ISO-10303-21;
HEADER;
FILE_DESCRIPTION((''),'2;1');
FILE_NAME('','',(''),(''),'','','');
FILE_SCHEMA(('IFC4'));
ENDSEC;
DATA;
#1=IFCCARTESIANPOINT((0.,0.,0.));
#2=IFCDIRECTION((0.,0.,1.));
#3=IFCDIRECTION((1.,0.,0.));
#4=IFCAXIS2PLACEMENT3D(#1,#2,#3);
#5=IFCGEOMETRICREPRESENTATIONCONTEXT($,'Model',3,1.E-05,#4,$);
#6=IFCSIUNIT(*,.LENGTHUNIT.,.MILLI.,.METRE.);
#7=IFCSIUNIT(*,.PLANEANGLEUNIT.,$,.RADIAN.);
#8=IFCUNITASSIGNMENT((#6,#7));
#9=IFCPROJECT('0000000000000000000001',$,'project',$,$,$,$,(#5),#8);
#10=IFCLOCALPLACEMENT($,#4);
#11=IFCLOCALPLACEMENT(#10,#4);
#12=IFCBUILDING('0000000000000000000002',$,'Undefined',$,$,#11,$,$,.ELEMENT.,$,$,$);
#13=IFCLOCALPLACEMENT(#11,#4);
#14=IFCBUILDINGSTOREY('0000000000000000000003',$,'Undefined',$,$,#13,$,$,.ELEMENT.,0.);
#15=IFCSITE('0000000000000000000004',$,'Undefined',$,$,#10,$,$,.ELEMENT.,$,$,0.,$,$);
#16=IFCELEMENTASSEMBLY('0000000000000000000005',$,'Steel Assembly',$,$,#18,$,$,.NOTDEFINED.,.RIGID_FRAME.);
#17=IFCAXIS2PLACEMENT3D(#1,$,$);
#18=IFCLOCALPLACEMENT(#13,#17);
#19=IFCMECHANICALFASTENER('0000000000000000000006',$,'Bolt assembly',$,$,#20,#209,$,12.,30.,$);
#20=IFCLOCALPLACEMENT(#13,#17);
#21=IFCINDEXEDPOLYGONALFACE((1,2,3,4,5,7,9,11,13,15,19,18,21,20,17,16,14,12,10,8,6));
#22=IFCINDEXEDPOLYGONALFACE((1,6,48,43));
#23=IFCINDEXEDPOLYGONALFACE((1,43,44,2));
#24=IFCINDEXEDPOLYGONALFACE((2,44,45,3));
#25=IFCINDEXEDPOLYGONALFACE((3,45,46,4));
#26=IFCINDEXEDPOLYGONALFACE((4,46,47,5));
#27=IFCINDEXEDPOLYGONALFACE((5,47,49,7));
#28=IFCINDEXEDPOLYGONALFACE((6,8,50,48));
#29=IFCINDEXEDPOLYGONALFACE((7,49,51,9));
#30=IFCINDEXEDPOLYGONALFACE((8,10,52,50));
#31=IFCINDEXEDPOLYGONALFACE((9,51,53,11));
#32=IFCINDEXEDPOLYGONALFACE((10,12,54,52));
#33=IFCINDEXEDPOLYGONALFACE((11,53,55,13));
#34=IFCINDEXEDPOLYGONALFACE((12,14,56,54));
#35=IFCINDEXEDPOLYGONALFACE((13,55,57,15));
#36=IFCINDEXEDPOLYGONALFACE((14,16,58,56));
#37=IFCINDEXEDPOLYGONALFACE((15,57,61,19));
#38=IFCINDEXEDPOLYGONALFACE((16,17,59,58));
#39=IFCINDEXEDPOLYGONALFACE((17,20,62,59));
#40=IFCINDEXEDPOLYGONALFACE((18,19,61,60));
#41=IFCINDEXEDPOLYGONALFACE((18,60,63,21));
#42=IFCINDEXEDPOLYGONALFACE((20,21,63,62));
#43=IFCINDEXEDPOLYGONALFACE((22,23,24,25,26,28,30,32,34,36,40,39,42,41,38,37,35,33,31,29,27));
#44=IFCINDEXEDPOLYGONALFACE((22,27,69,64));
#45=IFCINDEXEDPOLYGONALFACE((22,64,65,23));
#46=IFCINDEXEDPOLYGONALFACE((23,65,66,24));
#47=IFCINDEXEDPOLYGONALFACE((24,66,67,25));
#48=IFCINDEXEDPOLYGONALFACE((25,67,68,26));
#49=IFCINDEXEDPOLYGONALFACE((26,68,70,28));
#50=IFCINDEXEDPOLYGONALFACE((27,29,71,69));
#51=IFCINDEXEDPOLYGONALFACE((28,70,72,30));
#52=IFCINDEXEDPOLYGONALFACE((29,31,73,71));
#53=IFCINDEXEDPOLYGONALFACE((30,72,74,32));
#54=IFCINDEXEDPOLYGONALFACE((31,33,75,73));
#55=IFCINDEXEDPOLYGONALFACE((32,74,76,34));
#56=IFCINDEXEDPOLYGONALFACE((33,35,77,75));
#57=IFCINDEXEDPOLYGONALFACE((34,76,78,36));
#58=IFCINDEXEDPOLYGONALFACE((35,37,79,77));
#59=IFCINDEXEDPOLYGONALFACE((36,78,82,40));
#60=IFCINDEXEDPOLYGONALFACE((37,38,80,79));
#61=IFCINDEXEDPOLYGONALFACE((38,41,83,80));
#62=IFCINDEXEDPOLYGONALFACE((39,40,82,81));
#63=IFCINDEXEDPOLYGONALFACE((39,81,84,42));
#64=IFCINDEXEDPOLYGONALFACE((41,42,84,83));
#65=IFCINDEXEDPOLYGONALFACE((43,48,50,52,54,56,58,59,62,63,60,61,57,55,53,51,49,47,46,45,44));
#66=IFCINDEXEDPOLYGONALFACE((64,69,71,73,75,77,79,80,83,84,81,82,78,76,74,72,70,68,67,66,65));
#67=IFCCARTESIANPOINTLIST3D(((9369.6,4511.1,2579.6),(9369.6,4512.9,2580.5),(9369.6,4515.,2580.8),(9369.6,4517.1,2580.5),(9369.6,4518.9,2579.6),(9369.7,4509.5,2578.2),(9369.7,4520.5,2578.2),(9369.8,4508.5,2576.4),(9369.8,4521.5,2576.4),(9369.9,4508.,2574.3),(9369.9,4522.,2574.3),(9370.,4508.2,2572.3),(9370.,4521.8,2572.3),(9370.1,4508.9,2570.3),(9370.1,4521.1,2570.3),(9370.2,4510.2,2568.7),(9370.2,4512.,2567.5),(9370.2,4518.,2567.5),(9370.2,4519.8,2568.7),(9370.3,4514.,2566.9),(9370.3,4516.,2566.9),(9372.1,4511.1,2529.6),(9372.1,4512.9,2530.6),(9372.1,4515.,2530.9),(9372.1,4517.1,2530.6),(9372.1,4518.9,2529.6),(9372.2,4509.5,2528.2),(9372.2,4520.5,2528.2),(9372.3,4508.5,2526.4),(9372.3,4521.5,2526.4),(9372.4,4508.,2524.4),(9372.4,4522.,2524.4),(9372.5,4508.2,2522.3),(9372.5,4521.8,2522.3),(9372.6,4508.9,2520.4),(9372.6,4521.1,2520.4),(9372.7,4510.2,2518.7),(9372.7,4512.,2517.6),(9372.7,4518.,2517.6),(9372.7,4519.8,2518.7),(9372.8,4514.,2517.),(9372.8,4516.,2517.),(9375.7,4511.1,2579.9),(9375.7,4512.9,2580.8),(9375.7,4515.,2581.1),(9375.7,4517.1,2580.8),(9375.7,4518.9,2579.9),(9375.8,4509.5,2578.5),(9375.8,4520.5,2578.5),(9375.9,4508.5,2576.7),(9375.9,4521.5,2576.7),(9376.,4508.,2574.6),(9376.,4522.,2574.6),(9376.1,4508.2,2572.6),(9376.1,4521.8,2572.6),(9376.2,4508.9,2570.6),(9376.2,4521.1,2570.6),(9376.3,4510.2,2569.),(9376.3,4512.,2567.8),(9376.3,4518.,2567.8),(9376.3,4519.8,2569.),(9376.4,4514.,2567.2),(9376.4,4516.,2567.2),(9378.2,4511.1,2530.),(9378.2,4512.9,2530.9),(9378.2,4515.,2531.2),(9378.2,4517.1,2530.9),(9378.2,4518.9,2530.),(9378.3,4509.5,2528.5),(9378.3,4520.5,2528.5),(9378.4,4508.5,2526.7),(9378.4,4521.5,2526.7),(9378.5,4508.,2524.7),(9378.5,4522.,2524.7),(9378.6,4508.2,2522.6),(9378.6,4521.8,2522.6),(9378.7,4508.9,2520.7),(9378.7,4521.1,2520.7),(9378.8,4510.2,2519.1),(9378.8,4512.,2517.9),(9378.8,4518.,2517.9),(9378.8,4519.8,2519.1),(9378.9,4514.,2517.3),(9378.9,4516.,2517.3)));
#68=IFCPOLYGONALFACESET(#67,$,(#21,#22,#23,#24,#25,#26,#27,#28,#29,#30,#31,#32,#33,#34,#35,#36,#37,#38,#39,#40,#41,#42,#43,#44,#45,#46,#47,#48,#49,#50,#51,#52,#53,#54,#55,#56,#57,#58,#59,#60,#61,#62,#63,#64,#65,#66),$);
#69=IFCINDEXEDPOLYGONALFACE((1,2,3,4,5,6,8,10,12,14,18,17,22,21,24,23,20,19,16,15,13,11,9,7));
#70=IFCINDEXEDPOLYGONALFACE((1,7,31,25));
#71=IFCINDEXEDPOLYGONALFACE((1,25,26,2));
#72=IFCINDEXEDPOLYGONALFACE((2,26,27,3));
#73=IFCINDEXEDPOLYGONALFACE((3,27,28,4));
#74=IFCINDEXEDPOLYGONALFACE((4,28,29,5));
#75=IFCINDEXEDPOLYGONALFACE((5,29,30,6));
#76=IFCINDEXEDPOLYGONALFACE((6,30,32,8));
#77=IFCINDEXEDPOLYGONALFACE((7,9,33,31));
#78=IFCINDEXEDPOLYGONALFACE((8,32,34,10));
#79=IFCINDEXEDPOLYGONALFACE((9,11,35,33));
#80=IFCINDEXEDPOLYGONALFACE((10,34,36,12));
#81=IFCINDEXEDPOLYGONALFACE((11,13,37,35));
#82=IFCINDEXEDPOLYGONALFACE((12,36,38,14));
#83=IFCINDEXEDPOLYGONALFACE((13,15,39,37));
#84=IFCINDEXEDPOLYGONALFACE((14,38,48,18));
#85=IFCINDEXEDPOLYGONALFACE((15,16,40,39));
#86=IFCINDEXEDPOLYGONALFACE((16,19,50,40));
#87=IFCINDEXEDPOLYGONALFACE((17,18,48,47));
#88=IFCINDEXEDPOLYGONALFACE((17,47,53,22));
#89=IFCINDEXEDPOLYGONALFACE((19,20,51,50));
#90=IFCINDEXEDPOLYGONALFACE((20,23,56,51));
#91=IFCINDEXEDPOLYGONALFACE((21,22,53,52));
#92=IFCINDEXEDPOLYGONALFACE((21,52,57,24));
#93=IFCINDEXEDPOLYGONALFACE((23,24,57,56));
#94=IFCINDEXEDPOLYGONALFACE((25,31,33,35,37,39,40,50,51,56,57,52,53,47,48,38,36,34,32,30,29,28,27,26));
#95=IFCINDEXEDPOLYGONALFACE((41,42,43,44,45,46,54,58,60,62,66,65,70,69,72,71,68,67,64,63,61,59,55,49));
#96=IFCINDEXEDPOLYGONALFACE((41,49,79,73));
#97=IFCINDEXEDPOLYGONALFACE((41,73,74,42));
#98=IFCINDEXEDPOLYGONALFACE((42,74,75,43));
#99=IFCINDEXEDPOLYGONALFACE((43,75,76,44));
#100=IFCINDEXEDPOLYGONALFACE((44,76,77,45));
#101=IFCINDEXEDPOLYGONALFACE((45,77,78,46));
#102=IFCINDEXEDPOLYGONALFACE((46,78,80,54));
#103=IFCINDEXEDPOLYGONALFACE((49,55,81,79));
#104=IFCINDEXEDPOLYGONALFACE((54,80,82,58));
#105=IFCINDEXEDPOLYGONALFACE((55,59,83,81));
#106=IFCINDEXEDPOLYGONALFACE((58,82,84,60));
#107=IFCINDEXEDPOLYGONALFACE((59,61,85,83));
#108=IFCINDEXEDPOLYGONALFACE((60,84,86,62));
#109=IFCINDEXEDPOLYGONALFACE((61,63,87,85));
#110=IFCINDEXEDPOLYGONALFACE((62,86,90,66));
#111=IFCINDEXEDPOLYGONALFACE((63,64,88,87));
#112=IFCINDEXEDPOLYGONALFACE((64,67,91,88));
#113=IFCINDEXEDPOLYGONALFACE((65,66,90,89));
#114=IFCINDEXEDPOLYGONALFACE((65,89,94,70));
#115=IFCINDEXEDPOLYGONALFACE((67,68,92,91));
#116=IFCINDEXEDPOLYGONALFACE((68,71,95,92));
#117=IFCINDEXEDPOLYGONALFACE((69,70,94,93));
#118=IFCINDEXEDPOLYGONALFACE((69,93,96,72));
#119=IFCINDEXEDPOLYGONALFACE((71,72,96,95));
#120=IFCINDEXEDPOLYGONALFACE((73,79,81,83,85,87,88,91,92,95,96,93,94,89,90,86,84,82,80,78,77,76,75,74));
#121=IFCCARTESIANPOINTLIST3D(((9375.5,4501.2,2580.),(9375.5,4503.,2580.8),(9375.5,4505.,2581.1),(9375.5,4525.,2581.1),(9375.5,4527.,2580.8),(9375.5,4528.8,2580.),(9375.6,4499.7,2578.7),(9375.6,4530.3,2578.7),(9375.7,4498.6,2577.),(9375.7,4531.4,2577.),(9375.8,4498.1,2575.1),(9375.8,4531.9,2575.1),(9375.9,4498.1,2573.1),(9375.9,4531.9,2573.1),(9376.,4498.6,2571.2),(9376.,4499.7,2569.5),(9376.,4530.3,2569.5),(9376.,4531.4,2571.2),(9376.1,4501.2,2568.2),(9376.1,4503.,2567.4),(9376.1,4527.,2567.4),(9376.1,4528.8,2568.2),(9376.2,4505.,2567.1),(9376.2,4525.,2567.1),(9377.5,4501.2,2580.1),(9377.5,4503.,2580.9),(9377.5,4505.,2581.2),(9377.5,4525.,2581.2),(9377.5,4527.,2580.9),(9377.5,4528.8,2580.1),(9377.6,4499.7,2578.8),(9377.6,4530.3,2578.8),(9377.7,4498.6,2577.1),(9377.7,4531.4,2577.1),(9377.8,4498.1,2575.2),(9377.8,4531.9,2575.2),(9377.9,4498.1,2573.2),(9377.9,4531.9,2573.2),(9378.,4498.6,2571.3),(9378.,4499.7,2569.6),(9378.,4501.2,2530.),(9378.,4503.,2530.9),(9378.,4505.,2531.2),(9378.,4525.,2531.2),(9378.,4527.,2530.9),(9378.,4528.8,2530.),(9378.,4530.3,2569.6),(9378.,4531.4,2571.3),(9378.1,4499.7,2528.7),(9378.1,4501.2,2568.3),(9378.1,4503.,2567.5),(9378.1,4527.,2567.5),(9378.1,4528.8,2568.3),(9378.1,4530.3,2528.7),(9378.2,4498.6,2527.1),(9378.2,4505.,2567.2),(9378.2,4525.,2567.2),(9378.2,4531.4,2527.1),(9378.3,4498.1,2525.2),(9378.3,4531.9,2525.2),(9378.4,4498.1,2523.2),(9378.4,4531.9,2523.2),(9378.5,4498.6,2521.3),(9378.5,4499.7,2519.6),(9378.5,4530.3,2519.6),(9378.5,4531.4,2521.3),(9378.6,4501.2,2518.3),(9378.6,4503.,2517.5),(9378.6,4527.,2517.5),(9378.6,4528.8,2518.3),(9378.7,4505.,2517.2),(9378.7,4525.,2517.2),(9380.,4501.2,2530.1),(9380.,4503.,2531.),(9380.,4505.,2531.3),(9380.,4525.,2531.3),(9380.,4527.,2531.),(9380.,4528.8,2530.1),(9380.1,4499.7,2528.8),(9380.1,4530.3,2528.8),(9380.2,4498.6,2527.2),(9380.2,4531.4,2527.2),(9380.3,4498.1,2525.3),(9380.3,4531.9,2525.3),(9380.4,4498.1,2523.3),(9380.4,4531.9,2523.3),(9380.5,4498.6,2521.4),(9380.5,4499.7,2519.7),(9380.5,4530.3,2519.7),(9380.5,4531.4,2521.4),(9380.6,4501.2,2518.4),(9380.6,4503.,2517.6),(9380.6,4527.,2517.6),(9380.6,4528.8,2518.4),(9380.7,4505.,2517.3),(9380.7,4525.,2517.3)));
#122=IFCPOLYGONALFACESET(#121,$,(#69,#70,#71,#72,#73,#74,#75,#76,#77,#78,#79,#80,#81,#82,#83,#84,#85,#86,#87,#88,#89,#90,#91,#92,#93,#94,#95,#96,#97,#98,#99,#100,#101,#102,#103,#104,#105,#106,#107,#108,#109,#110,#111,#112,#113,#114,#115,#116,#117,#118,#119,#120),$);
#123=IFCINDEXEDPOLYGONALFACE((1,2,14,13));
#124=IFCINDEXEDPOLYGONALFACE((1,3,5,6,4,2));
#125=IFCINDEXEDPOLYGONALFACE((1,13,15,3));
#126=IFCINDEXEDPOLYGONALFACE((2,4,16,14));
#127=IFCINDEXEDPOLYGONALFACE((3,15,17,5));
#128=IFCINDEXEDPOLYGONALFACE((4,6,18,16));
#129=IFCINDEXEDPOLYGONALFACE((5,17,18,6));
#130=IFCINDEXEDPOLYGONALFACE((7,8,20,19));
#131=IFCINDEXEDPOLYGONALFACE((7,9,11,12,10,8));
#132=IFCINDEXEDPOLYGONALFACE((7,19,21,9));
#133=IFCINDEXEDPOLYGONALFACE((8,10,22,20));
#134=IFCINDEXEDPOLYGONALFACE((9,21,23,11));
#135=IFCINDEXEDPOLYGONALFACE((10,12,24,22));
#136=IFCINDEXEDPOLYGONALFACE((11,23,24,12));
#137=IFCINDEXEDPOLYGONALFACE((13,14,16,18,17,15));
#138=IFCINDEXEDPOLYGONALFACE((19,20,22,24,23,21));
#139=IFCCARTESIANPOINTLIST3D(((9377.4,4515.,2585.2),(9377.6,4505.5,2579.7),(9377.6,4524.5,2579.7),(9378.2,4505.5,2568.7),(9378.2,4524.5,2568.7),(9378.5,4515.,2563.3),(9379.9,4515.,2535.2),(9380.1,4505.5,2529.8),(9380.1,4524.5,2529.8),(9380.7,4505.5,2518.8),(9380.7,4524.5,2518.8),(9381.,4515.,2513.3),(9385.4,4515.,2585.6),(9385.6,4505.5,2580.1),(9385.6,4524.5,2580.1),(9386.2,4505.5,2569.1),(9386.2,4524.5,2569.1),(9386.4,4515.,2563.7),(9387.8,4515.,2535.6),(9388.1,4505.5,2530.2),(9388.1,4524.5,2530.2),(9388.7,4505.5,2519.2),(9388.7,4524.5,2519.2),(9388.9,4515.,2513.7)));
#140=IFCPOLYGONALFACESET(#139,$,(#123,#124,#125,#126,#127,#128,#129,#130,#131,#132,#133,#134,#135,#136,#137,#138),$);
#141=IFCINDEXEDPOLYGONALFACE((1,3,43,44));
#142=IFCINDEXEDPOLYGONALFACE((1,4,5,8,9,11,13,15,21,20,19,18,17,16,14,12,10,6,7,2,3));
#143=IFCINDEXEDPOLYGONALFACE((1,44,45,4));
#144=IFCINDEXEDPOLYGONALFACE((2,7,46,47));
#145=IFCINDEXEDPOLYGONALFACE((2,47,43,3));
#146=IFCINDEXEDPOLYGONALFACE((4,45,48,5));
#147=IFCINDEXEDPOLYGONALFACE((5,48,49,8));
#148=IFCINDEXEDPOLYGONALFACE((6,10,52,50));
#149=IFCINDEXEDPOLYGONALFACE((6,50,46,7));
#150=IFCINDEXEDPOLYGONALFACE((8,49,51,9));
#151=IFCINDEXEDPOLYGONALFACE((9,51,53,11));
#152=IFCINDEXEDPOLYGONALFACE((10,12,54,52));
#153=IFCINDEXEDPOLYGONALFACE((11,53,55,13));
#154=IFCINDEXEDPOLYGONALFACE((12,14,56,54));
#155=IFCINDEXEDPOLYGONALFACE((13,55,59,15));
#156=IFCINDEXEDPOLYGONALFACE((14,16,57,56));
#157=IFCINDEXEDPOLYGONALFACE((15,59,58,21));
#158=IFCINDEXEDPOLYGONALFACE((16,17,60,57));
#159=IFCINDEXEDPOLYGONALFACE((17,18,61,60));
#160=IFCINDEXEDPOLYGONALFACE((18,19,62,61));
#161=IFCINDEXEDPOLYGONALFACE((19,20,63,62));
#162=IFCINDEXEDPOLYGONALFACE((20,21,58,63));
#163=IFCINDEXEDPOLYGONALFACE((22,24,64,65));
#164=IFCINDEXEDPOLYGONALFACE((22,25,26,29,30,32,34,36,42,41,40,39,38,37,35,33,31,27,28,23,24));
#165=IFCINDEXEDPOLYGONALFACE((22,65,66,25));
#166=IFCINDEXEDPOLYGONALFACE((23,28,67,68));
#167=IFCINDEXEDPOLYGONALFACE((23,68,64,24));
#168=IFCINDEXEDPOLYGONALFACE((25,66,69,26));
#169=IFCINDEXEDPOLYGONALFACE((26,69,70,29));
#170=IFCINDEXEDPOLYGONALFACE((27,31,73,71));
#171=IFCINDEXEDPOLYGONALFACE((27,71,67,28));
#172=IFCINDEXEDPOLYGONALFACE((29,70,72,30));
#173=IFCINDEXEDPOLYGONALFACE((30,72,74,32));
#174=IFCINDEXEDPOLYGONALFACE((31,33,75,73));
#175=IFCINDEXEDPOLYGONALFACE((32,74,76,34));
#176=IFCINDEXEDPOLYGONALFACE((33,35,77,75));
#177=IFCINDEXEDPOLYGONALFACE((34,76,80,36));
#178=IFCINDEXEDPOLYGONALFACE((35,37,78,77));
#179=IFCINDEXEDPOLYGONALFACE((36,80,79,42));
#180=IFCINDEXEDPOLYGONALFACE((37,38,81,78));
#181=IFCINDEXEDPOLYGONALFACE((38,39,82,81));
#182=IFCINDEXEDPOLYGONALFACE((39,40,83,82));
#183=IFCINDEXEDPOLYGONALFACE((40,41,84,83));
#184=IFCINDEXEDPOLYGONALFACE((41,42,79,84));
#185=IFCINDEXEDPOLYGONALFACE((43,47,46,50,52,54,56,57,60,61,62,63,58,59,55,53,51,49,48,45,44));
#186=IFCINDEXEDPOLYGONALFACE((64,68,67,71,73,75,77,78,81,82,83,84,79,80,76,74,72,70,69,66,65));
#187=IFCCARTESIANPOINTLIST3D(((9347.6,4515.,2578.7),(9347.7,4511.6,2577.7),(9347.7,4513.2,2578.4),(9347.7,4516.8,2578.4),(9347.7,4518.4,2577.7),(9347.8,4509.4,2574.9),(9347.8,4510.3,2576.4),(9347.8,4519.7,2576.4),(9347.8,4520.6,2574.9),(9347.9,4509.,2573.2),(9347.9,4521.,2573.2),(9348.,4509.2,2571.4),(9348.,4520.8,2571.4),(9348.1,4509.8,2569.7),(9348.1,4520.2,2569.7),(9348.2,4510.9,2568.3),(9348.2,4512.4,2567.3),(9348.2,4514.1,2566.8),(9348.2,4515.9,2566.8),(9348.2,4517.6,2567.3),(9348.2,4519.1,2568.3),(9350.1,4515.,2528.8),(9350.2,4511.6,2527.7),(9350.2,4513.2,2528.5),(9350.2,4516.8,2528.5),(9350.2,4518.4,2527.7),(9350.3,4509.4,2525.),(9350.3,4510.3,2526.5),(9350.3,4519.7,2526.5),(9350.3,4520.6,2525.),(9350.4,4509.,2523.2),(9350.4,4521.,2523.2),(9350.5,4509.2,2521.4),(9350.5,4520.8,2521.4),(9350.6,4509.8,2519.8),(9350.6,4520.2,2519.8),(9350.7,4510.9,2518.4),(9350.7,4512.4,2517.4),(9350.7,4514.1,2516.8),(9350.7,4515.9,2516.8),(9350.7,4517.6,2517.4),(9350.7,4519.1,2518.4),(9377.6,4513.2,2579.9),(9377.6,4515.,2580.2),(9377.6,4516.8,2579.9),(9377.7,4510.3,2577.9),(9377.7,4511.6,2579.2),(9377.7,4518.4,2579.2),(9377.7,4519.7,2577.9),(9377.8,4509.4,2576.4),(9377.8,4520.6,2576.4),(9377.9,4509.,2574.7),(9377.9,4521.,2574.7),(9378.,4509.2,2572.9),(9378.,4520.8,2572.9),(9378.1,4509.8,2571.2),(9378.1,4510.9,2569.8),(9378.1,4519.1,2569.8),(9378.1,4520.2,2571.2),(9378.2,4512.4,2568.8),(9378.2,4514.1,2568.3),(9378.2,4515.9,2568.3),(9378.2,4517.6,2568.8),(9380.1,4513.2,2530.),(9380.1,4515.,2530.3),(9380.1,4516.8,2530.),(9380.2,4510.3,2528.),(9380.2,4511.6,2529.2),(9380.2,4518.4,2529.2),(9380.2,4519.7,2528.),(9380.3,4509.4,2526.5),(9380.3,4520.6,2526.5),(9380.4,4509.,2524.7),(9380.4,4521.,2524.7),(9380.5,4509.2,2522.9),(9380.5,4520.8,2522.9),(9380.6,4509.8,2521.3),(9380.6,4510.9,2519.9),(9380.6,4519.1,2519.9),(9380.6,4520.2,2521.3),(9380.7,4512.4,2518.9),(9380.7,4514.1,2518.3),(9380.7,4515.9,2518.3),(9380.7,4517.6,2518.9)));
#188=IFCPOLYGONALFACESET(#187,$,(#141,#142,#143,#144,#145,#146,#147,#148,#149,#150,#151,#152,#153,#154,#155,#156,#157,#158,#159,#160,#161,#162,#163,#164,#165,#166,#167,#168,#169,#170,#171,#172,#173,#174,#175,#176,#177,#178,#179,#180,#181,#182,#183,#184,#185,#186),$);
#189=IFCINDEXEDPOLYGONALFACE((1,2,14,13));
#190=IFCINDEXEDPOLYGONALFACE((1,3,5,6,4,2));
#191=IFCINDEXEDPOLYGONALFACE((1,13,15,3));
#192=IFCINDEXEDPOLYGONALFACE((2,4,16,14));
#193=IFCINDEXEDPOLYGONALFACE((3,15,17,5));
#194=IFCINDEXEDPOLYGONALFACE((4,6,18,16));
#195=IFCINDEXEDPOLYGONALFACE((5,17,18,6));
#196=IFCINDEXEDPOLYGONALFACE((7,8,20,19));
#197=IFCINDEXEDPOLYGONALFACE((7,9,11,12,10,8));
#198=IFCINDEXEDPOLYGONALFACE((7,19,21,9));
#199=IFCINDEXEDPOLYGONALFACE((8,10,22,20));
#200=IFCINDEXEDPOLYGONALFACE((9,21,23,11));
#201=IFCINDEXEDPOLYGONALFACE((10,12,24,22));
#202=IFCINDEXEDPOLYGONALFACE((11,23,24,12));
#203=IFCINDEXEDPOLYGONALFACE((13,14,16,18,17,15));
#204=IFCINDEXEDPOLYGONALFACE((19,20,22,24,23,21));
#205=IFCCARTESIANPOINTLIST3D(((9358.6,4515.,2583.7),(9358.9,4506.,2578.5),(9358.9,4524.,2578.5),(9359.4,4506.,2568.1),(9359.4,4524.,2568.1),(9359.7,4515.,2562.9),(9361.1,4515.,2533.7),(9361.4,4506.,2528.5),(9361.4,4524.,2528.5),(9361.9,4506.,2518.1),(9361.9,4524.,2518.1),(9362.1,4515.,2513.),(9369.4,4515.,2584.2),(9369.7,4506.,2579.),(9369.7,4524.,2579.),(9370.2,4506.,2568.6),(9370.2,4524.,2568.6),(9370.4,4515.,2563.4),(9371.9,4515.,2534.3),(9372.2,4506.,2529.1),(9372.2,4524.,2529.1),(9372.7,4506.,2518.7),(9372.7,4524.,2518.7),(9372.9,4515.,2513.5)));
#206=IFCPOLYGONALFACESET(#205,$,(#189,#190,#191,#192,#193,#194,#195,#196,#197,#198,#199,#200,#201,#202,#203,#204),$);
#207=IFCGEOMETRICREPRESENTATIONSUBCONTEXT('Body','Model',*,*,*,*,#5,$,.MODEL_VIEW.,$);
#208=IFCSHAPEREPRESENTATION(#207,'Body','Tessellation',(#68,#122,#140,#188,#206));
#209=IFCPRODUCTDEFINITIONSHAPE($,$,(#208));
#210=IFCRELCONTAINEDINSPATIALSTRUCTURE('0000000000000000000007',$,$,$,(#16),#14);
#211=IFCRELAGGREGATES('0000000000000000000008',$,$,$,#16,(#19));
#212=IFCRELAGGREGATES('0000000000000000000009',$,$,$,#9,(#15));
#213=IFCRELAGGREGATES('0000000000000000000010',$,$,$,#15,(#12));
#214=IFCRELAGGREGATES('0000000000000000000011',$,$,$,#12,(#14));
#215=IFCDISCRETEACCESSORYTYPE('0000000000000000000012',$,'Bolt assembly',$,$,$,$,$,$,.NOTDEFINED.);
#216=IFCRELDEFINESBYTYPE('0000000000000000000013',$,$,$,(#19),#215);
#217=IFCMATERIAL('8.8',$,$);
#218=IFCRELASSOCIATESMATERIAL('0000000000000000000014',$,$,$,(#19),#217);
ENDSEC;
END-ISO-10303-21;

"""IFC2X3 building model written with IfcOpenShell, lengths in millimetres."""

from ifc_helpers import new_model, si_unit, frame, frame_2d, origin_with_axes, origin_2d_with_axis, place, context, subcontext, project, spatial, polyline, circle_curve, parameter, trimmed, segment, composite_curve, circle, outline, extrude, source, transform, mapped, material, type_object, element, aggregate, save


model = new_model("IFC2X3")

# Units and contexts
model_context = context("Model", 3, precision=1e-05, world=origin_with_axes())
body_context = subcontext(model_context, "Body", "Model", "MODEL_VIEW")
ifc_project = project(units=[si_unit("LENGTHUNIT", "METRE", prefix="MILLI"), si_unit("PLANEANGLEUNIT", "RADIAN")], contexts=[model_context])

# Site, building, storey
site_placement = place(None, origin_with_axes())
site = spatial("IfcSite", under=ifc_project, at=site_placement, Name="Undefined", CompositionType="ELEMENT", RefElevation=0.0)
building_placement = place(site_placement, origin_with_axes())
building = spatial("IfcBuilding", under=site, at=building_placement, Name="Undefined", CompositionType="ELEMENT")
storey_placement = place(building_placement, origin_with_axes())
storey = spatial("IfcBuildingStorey", under=building, at=storey_placement, Name="Undefined", CompositionType="ELEMENT", Elevation=0.0)

# Element assembly
assembly_1_placement = place(storey_placement, origin_with_axes())
assembly_1 = element("IfcElementAssembly", 1, at=assembly_1_placement, inside=storey, Name="Steel Assembly", AssemblyPlace="NOTDEFINED", PredefinedType="RIGID_FRAME")

# Mechanical fastener
discrete_accessory_type_1 = type_object("IfcDiscreteAccessoryType", Name="Bolt assembly")
ifc_material_1 = material(Name="8.8")
shared_shape_1 = source(origin_with_axes(), body_context, "Body", "SweptSolid", [
    extrude(circle(Radius=7.0, at=origin_2d_with_axis()), frame((0.0, -3.1, 0.0), z_axis=(0.0, 1.0, 0.0), x_axis=(1.0, 0.0, 0.0)), (0.0, 0.0, 1.0), 6.1),
    extrude(outline(composite_curve([segment(polyline([(7.0, 10.0), (7.0, -10.0)]), True, "CONTINUOUS"), segment(trimmed(circle_curve(frame_2d((0.0, -10.0), x_axis=(1.0, 0.0)), 7.0), [parameter(0.0)], [parameter(3.1416)], False, "PARAMETER"), True, "CONTINUOUS"), segment(polyline([(-7.0, -10.0), (-7.0, 10.0)]), True, "CONTINUOUS"), segment(trimmed(circle_curve(frame_2d((0.0, 10.0), x_axis=(-1.0, 0.0)), 7.0), [parameter(0.0)], [parameter(3.1416)], False, "PARAMETER"), True, "DISCONTINUOUS")], self_intersect=False)), frame((0.0, -4.9, 0.0), z_axis=(0.0, 1.0, 0.0), x_axis=(1.0, 0.0, 0.0)), (0.0, 0.0, 1.0), 2.0),
    extrude(outline(polyline([(11.0, 0.0), (5.5, 9.5), (-5.5, 9.5), (-11.0, 0.0), (-5.5, -9.5), (5.5, -9.5), (11.0, 0.0)])), frame((0.0, -13.0, 0.0), z_axis=(0.0, 1.0, 0.0), x_axis=(1.0, 0.0, 0.0)), (0.0, 0.0, 1.0), 8.0),
    extrude(circle(Radius=6.0, at=origin_2d_with_axis()), frame((0.0, -5.0, 0.0), z_axis=(0.0, 1.0, 0.0), x_axis=(1.0, 0.0, 0.0)), (0.0, 0.0, 1.0), 30.0),
    extrude(outline(polyline([(10.4, 0.0), (5.2, 9.0), (-5.2, 9.0), (-10.4, 0.0), (-5.2, -9.0), (5.2, -9.0), (10.4, 0.0)])), frame((0.0, 3.0, 0.0), z_axis=(0.0, 1.0, 0.0), x_axis=(1.0, 0.0, 0.0)), (0.0, 0.0, 1.0), 10.8),
])
mechanical_fastener_1_placement = place(assembly_1_placement, frame((9376.7, 4560.0, 2499.1), z_axis=(0.0, -1.0, 0.0), x_axis=(-0.049938, 0.0, 0.998752)))
mechanical_fastener_1 = element("IfcMechanicalFastener", 2, at=mechanical_fastener_1_placement, type_object=discrete_accessory_type_1, material=ifc_material_1, Name="Bolt assembly", NominalDiameter=12.0, NominalLength=30.0, context=body_context, shape_type="MappedRepresentation", body=[
    mapped(shared_shape_1, transform((25.0, 0.0, 45.0))),
    mapped(shared_shape_1, transform((75.0, 0.0, 45.0))),
])
aggregate(assembly_1, [mechanical_fastener_1])

save(model, "model.ifc")
